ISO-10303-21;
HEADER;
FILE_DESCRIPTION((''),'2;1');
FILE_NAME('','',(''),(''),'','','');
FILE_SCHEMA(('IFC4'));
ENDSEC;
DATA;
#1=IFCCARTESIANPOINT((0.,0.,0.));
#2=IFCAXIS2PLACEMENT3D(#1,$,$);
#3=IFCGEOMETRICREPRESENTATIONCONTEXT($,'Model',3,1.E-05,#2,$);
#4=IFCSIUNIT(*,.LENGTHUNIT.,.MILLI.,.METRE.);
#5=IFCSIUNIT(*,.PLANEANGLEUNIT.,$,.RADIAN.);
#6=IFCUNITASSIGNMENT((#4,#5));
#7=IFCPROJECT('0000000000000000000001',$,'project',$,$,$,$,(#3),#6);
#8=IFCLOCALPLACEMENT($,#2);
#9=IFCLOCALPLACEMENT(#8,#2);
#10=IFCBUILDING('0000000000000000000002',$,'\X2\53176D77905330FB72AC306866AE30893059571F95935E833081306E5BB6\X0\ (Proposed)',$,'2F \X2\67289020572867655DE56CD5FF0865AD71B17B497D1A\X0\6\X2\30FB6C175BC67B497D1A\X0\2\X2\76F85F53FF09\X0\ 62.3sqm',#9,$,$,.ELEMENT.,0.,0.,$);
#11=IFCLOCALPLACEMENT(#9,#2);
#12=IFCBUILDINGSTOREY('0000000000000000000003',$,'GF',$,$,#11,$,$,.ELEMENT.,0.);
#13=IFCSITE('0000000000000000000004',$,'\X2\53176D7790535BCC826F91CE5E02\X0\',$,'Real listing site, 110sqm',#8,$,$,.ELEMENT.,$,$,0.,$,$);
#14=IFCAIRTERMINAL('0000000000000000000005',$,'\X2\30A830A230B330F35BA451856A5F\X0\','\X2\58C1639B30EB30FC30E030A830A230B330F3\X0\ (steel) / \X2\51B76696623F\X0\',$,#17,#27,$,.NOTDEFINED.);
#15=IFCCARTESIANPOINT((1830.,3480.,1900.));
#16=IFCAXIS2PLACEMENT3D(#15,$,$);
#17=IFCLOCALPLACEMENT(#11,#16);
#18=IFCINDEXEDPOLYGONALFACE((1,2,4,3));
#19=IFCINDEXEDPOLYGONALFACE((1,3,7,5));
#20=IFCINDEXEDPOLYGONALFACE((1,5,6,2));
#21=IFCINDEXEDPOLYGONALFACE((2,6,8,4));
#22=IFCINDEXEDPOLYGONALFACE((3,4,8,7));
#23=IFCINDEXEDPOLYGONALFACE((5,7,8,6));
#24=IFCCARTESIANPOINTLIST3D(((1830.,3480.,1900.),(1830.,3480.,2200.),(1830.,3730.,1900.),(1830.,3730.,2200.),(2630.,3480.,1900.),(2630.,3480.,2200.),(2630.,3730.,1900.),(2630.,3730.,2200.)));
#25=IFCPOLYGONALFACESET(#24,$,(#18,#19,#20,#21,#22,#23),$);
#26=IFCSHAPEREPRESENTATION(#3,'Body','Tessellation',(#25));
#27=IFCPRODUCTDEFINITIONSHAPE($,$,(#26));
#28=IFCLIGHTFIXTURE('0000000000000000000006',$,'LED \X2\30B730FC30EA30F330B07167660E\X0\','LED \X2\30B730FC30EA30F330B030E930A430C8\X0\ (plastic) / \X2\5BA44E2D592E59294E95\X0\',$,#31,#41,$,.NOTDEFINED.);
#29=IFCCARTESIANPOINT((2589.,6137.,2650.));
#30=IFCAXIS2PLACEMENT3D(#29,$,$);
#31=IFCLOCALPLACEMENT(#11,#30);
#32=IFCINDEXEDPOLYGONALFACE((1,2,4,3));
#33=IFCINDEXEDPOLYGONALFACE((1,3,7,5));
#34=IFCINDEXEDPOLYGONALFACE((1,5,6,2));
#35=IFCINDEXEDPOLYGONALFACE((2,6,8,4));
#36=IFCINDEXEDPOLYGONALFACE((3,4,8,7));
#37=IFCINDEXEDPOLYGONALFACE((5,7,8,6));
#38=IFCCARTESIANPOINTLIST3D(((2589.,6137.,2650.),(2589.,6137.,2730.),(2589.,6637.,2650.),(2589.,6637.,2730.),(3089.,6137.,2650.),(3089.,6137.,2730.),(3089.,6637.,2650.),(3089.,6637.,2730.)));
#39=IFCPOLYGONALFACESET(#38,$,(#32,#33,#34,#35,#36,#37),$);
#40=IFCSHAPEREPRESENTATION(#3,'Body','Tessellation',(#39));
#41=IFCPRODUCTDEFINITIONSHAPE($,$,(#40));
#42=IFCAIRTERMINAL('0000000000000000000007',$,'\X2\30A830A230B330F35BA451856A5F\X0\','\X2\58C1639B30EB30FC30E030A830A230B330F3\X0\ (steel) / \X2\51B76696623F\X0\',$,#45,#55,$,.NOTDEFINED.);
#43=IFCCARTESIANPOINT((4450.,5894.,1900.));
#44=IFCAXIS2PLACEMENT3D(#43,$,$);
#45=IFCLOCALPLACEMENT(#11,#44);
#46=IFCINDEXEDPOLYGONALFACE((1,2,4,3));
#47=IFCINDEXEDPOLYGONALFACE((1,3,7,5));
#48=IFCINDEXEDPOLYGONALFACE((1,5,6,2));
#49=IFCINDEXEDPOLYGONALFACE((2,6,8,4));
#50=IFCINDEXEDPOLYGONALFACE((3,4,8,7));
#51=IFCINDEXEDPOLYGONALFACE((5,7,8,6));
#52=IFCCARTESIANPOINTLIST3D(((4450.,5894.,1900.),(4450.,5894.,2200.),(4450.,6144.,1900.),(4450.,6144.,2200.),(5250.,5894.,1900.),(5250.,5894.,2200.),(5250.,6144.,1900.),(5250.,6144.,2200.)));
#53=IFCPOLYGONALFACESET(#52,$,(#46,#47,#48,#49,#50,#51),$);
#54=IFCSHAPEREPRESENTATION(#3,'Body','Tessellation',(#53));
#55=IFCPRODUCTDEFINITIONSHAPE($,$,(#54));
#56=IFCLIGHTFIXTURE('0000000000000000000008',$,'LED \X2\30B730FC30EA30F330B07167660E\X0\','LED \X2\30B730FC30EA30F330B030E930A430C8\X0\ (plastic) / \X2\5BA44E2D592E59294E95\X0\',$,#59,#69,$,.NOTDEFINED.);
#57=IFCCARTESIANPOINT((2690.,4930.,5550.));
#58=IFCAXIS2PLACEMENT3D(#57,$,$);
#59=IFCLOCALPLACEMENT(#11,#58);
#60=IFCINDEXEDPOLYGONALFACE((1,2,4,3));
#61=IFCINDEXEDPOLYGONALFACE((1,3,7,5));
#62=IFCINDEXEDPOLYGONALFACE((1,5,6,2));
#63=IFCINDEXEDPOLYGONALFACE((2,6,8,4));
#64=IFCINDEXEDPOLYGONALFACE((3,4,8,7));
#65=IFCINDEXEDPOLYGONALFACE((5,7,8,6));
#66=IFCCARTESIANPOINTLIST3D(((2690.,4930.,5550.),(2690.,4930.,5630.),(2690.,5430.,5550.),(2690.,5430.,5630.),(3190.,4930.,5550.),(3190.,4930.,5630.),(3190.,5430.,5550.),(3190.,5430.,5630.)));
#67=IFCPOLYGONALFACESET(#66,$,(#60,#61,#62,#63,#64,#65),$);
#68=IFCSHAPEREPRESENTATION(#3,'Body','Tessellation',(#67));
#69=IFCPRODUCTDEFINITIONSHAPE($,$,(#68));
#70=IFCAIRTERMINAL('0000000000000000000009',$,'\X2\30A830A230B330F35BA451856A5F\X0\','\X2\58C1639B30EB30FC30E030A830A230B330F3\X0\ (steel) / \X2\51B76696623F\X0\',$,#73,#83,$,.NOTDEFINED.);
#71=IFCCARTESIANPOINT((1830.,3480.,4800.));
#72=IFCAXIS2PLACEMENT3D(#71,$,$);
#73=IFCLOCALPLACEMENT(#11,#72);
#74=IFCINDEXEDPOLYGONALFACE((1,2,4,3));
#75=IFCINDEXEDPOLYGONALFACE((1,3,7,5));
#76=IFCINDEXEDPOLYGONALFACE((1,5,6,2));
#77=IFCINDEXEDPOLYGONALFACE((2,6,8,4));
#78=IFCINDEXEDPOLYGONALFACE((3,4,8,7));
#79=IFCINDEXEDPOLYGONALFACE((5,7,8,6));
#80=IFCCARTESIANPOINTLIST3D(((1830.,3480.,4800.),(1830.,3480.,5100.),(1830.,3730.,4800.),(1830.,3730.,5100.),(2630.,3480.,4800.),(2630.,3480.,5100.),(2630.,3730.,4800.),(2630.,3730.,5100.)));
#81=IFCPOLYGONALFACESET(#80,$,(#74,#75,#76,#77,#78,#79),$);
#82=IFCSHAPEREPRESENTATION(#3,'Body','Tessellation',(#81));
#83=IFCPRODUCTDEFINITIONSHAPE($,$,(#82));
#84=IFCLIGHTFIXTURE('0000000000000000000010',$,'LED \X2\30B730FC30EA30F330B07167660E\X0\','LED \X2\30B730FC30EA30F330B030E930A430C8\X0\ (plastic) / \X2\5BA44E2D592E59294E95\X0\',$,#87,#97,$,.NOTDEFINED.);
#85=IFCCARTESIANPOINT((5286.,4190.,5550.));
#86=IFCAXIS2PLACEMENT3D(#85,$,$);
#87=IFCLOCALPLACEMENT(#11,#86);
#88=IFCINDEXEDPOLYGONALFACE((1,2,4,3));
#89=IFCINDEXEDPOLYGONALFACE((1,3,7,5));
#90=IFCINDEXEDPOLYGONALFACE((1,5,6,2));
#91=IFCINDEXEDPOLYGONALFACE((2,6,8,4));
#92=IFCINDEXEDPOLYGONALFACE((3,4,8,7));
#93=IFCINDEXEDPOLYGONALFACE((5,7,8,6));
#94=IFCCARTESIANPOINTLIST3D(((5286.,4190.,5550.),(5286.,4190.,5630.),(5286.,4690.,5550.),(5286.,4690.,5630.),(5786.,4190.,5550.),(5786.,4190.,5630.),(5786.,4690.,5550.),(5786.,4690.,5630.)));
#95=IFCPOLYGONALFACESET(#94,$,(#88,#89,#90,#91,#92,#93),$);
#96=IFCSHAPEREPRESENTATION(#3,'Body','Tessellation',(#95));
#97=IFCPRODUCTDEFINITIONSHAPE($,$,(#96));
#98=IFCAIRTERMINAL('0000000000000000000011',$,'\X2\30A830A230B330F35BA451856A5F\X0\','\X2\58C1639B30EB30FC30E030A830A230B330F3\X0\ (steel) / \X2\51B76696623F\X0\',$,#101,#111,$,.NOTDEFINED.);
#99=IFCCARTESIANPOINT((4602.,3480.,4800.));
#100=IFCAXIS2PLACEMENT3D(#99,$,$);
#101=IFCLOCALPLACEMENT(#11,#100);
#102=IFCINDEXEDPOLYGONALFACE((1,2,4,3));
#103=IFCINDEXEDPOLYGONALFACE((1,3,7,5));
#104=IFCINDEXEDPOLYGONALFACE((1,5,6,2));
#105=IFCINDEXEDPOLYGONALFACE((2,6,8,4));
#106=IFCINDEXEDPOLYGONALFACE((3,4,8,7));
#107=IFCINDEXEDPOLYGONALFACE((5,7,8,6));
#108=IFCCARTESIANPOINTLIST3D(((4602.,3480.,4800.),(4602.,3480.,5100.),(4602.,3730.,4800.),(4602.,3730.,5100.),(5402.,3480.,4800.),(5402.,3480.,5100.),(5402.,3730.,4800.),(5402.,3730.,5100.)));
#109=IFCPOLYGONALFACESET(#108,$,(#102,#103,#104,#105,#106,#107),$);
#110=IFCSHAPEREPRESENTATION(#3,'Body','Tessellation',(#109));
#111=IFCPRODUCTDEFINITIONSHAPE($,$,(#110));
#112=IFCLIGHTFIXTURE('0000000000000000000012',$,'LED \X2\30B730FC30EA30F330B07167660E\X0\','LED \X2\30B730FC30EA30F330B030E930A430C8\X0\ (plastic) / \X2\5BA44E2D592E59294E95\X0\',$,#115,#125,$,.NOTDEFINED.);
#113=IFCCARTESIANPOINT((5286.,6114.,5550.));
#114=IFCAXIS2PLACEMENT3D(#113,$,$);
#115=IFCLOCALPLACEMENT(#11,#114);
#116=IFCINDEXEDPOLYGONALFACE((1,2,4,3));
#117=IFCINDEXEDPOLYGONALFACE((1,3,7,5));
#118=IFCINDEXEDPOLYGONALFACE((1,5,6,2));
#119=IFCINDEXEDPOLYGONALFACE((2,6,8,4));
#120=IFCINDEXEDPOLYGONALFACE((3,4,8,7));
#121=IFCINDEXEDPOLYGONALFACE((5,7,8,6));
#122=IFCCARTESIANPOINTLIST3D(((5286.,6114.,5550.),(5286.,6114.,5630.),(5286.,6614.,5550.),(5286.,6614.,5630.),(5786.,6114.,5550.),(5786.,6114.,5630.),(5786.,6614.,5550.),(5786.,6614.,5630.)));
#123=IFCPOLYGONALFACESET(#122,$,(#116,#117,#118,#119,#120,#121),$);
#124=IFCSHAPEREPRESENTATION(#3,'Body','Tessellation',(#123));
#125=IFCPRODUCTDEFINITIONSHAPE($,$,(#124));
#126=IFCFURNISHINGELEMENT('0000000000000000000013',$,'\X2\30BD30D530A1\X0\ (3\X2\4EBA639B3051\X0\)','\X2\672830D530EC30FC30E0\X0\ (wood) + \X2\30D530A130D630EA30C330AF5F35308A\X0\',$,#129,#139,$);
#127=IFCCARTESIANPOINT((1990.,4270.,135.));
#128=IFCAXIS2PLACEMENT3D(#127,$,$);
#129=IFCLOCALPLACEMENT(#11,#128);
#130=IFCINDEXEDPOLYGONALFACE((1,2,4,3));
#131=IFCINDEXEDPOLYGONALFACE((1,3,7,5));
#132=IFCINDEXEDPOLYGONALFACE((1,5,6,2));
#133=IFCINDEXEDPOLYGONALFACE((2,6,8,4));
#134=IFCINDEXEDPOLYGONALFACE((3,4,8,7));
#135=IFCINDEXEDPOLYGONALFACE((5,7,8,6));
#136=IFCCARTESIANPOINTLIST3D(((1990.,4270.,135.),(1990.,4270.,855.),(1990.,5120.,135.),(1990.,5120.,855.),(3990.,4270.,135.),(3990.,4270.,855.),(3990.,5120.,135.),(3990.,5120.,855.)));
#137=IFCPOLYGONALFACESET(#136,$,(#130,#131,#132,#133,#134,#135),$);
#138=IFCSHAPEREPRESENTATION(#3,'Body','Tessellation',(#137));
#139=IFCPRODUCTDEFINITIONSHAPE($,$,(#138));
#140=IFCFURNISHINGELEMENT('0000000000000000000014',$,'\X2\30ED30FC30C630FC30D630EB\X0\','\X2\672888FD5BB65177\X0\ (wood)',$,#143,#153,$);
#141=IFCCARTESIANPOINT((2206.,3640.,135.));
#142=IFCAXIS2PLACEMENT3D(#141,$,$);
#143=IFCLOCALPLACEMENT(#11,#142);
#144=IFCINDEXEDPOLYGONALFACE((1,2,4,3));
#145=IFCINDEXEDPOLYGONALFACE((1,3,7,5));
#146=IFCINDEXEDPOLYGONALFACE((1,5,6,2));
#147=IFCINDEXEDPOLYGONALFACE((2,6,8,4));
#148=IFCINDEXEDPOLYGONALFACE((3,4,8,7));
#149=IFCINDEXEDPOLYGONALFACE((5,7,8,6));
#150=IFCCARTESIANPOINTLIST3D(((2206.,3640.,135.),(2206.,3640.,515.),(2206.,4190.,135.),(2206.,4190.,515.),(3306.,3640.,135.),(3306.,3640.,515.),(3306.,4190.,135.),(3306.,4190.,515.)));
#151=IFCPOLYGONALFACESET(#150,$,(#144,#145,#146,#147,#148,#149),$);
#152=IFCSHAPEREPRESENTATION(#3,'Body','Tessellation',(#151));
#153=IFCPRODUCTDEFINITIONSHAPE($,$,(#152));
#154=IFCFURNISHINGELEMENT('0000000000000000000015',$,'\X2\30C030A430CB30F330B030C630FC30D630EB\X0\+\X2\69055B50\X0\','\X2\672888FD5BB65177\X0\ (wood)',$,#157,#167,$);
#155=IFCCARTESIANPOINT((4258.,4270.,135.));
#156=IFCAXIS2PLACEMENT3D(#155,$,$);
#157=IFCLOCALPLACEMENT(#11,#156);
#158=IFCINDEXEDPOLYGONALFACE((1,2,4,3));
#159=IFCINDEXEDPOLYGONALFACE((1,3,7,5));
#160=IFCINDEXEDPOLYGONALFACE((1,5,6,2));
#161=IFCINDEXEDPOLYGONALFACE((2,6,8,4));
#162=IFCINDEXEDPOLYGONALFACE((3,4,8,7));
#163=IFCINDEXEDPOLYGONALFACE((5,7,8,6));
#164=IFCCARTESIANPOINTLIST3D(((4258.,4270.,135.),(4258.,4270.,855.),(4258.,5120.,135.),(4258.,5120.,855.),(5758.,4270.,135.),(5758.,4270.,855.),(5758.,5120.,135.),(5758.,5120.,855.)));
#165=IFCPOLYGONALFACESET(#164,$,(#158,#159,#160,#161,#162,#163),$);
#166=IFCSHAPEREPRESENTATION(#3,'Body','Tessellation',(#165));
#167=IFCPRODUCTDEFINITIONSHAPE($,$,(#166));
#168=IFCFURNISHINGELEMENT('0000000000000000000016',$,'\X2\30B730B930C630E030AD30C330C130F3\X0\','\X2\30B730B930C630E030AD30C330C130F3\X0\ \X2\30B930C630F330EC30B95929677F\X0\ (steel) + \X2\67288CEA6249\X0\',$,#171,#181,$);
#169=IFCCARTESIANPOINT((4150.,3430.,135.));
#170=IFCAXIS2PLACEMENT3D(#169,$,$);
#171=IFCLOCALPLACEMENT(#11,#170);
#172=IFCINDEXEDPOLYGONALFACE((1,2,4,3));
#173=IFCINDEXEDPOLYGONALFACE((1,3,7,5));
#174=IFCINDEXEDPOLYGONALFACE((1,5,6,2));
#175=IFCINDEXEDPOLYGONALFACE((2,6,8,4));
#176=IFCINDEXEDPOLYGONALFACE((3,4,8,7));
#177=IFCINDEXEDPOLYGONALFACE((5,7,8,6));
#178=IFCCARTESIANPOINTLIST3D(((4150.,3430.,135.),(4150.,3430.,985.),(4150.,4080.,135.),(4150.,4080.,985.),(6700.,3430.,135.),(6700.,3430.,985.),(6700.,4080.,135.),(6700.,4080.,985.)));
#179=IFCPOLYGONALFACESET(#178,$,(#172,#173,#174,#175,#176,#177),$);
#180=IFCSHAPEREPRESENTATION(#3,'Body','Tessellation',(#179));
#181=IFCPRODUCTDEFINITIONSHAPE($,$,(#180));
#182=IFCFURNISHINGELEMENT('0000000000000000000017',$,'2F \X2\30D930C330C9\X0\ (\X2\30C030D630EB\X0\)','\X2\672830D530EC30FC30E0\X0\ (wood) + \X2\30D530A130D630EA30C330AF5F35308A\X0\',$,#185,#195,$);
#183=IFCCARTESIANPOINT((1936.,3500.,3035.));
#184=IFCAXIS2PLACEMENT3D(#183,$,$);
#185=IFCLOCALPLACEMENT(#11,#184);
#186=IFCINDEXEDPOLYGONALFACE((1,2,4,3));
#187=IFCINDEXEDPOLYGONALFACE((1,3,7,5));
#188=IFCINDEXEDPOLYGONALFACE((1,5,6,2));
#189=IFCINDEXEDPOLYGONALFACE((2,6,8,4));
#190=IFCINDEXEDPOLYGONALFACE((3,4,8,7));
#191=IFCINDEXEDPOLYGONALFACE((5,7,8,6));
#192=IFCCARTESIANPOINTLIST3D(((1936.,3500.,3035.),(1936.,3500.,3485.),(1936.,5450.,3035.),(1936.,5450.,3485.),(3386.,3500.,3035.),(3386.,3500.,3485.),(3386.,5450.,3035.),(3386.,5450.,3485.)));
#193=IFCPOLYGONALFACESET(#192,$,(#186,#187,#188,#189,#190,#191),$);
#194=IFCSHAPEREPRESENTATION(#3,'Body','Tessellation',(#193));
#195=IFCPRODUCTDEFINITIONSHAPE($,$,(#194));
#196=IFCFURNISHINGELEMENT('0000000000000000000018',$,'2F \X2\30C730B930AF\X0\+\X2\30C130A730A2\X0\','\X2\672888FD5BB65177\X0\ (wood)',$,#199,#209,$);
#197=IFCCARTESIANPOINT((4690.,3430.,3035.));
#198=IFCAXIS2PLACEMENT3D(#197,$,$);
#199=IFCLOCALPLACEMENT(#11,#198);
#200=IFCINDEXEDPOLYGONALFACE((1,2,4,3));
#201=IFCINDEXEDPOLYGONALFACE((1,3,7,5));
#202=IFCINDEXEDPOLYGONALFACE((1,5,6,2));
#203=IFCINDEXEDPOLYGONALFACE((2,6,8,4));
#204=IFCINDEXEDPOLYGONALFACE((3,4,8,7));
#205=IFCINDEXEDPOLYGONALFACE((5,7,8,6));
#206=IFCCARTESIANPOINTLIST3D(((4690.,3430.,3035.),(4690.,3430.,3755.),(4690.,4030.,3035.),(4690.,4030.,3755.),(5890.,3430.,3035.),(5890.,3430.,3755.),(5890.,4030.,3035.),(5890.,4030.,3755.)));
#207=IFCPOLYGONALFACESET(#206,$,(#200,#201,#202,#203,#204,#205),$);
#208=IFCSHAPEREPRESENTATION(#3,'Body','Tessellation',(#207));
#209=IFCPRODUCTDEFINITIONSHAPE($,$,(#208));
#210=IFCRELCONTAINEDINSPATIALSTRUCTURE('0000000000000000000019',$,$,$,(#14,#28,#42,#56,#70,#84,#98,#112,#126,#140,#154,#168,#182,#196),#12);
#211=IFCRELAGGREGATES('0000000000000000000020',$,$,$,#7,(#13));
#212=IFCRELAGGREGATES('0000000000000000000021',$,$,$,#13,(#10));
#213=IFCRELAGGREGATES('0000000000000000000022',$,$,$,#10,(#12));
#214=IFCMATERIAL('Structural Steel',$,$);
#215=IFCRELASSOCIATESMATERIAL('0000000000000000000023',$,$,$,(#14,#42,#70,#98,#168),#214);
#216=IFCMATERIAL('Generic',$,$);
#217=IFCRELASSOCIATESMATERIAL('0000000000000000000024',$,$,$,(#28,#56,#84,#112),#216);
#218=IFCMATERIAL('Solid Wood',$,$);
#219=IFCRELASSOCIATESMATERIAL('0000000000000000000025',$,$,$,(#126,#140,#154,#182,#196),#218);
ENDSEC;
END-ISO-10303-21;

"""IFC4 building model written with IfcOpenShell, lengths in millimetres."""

from ifc_helpers import new_model, si_unit, frame, frame_2d, origin, place, context, project, spatial, rectangle, extrude, material, element, save


model = new_model("IFC4")

# Units and contexts
model_context = context("Model", 3, precision=1e-05, world=origin())
ifc_project = project(units=[si_unit("LENGTHUNIT", "METRE", prefix="MILLI"), si_unit("PLANEANGLEUNIT", "RADIAN")], contexts=[model_context])

# Site, building, storey
site_placement = place(None, origin())
site = spatial("IfcSite", under=ifc_project, at=site_placement, Name="北海道富良野市", ObjectType="Real listing site, 110sqm", CompositionType="ELEMENT", RefElevation=0.0)
building_placement = place(site_placement, origin())
building = spatial("IfcBuilding", under=site, at=building_placement, Name="北海道・犬と暮らす土間広めの家 (Proposed)", ObjectType="2F 木造在来工法（断熱等級6・気密等級2相当） 62.3sqm", CompositionType="ELEMENT", ElevationOfRefHeight=0.0, ElevationOfTerrain=0.0)
storey_placement = place(building_placement, origin())
storey = spatial("IfcBuildingStorey", under=building, at=storey_placement, Name="GF", CompositionType="ELEMENT", Elevation=0.0)

# Shared definitions
ifc_material_1 = material(Name="Solid Wood")

# Shared definitions
ifc_material_2 = material(Name="Structural Steel")

# Shared definitions
ifc_material_3 = material(Name="Generic")

# Air terminal
air_terminal_1_placement = place(storey_placement, frame((1830.0, 3480.0, 1900.0)))
element("IfcAirTerminal", 1, at=air_terminal_1_placement, inside=storey, material=ifc_material_2, Name="エアコン室内機", Description="壁掛ルームエアコン (steel) / 冷暖房", PredefinedType="NOTDEFINED", context=model_context, shape_type="SweptSolid", body=[
    extrude(rectangle(XDim=800.0, YDim=250.0, at=frame_2d((400.0, 125.0))), frame((1830.0, 3480.0, 1900.0)), (0.0, 0.0, 1.0), 300.0),
])

# Light fixture
light_fixture_1_placement = place(storey_placement, frame((2589.0, 6137.0, 2650.0)))
element("IfcLightFixture", 2, at=light_fixture_1_placement, inside=storey, material=ifc_material_3, Name="LED シーリング照明", Description="LED シーリングライト (plastic) / 室中央天井", PredefinedType="NOTDEFINED", context=model_context, shape_type="SweptSolid", body=[
    extrude(rectangle(XDim=500.0, YDim=500.0, at=frame_2d((250.0, 250.0))), frame((2589.0, 6137.0, 2650.0)), (0.0, 0.0, 1.0), 80.0),
])

# Air terminal
air_terminal_2_placement = place(storey_placement, frame((4450.0, 5894.0, 1900.0)))
element("IfcAirTerminal", 3, at=air_terminal_2_placement, inside=storey, material=ifc_material_2, Name="エアコン室内機", Description="壁掛ルームエアコン (steel) / 冷暖房", PredefinedType="NOTDEFINED", context=model_context, shape_type="SweptSolid", body=[
    extrude(rectangle(XDim=800.0, YDim=250.0, at=frame_2d((400.0, 125.0))), frame((4450.0, 5894.0, 1900.0)), (0.0, 0.0, 1.0), 300.0),
])

# Light fixture
light_fixture_2_placement = place(storey_placement, frame((2690.0, 4930.0, 5550.0)))
element("IfcLightFixture", 4, at=light_fixture_2_placement, inside=storey, material=ifc_material_3, Name="LED シーリング照明", Description="LED シーリングライト (plastic) / 室中央天井", PredefinedType="NOTDEFINED", context=model_context, shape_type="SweptSolid", body=[
    extrude(rectangle(XDim=500.0, YDim=500.0, at=frame_2d((250.0, 250.0))), frame((2690.0, 4930.0, 5550.0)), (0.0, 0.0, 1.0), 80.0),
])

# Air terminal
air_terminal_3_placement = place(storey_placement, frame((1830.0, 3480.0, 4800.0)))
element("IfcAirTerminal", 5, at=air_terminal_3_placement, inside=storey, material=ifc_material_2, Name="エアコン室内機", Description="壁掛ルームエアコン (steel) / 冷暖房", PredefinedType="NOTDEFINED", context=model_context, shape_type="SweptSolid", body=[
    extrude(rectangle(XDim=800.0, YDim=250.0, at=frame_2d((400.0, 125.0))), frame((1830.0, 3480.0, 4800.0)), (0.0, 0.0, 1.0), 300.0),
])

# Light fixture
light_fixture_3_placement = place(storey_placement, frame((5286.0, 4190.0, 5550.0)))
element("IfcLightFixture", 6, at=light_fixture_3_placement, inside=storey, material=ifc_material_3, Name="LED シーリング照明", Description="LED シーリングライト (plastic) / 室中央天井", PredefinedType="NOTDEFINED", context=model_context, shape_type="SweptSolid", body=[
    extrude(rectangle(XDim=500.0, YDim=500.0, at=frame_2d((250.0, 250.0))), frame((5286.0, 4190.0, 5550.0)), (0.0, 0.0, 1.0), 80.0),
])

# Air terminal
air_terminal_4_placement = place(storey_placement, frame((4602.0, 3480.0, 4800.0)))
element("IfcAirTerminal", 7, at=air_terminal_4_placement, inside=storey, material=ifc_material_2, Name="エアコン室内機", Description="壁掛ルームエアコン (steel) / 冷暖房", PredefinedType="NOTDEFINED", context=model_context, shape_type="SweptSolid", body=[
    extrude(rectangle(XDim=800.0, YDim=250.0, at=frame_2d((400.0, 125.0))), frame((4602.0, 3480.0, 4800.0)), (0.0, 0.0, 1.0), 300.0),
])

# Light fixture
light_fixture_4_placement = place(storey_placement, frame((5286.0, 6114.0, 5550.0)))
element("IfcLightFixture", 8, at=light_fixture_4_placement, inside=storey, material=ifc_material_3, Name="LED シーリング照明", Description="LED シーリングライト (plastic) / 室中央天井", PredefinedType="NOTDEFINED", context=model_context, shape_type="SweptSolid", body=[
    extrude(rectangle(XDim=500.0, YDim=500.0, at=frame_2d((250.0, 250.0))), frame((5286.0, 6114.0, 5550.0)), (0.0, 0.0, 1.0), 80.0),
])

# Furnishing elements
furnishing_1_placement = place(storey_placement, frame((1990.0, 4270.0, 135.0)))
element("IfcFurnishingElement", 9, at=furnishing_1_placement, inside=storey, material=ifc_material_1, Name="ソファ (3人掛け)", Description="木フレーム (wood) + ファブリック張り", context=model_context, shape_type="SweptSolid", body=[
    extrude(rectangle(XDim=2000.0, YDim=850.0, at=frame_2d((1000.0, 425.0))), frame((1990.0, 4270.0, 135.0)), (0.0, 0.0, 1.0), 720.0),
])
furnishing_2_placement = place(storey_placement, frame((2206.0, 3640.0, 135.0)))
element("IfcFurnishingElement", 10, at=furnishing_2_placement, inside=storey, material=ifc_material_1, Name="ローテーブル", Description="木製家具 (wood)", context=model_context, shape_type="SweptSolid", body=[
    extrude(rectangle(XDim=1100.0, YDim=550.0, at=frame_2d((550.0, 275.0))), frame((2206.0, 3640.0, 135.0)), (0.0, 0.0, 1.0), 380.0),
])
furnishing_3_placement = place(storey_placement, frame((4258.0, 4270.0, 135.0)))
element("IfcFurnishingElement", 11, at=furnishing_3_placement, inside=storey, material=ifc_material_1, Name="ダイニングテーブル+椅子", Description="木製家具 (wood)", context=model_context, shape_type="SweptSolid", body=[
    extrude(rectangle(XDim=1500.0, YDim=850.0, at=frame_2d((750.0, 425.0))), frame((4258.0, 4270.0, 135.0)), (0.0, 0.0, 1.0), 720.0),
])
furnishing_4_placement = place(storey_placement, frame((4150.0, 3430.0, 135.0)))
element("IfcFurnishingElement", 12, at=furnishing_4_placement, inside=storey, material=ifc_material_2, Name="システムキッチン", Description="システムキッチン ステンレス天板 (steel) + 木質扉", context=model_context, shape_type="SweptSolid", body=[
    extrude(rectangle(XDim=2550.0, YDim=650.0, at=frame_2d((1275.0, 325.0))), frame((4150.0, 3430.0, 135.0)), (0.0, 0.0, 1.0), 850.0),
])
furnishing_5_placement = place(storey_placement, frame((1936.0, 3500.0, 3035.0)))
element("IfcFurnishingElement", 13, at=furnishing_5_placement, inside=storey, material=ifc_material_1, Name="2F ベッド (ダブル)", Description="木フレーム (wood) + ファブリック張り", context=model_context, shape_type="SweptSolid", body=[
    extrude(rectangle(XDim=1450.0, YDim=1950.0, at=frame_2d((725.0, 975.0))), frame((1936.0, 3500.0, 3035.0)), (0.0, 0.0, 1.0), 450.0),
])
furnishing_6_placement = place(storey_placement, frame((4690.0, 3430.0, 3035.0)))
element("IfcFurnishingElement", 14, at=furnishing_6_placement, inside=storey, material=ifc_material_1, Name="2F デスク+チェア", Description="木製家具 (wood)", context=model_context, shape_type="SweptSolid", body=[
    extrude(rectangle(XDim=1200.0, YDim=600.0, at=frame_2d((600.0, 300.0))), frame((4690.0, 3430.0, 3035.0)), (0.0, 0.0, 1.0), 720.0),
])

save(model, "model.ifc")
